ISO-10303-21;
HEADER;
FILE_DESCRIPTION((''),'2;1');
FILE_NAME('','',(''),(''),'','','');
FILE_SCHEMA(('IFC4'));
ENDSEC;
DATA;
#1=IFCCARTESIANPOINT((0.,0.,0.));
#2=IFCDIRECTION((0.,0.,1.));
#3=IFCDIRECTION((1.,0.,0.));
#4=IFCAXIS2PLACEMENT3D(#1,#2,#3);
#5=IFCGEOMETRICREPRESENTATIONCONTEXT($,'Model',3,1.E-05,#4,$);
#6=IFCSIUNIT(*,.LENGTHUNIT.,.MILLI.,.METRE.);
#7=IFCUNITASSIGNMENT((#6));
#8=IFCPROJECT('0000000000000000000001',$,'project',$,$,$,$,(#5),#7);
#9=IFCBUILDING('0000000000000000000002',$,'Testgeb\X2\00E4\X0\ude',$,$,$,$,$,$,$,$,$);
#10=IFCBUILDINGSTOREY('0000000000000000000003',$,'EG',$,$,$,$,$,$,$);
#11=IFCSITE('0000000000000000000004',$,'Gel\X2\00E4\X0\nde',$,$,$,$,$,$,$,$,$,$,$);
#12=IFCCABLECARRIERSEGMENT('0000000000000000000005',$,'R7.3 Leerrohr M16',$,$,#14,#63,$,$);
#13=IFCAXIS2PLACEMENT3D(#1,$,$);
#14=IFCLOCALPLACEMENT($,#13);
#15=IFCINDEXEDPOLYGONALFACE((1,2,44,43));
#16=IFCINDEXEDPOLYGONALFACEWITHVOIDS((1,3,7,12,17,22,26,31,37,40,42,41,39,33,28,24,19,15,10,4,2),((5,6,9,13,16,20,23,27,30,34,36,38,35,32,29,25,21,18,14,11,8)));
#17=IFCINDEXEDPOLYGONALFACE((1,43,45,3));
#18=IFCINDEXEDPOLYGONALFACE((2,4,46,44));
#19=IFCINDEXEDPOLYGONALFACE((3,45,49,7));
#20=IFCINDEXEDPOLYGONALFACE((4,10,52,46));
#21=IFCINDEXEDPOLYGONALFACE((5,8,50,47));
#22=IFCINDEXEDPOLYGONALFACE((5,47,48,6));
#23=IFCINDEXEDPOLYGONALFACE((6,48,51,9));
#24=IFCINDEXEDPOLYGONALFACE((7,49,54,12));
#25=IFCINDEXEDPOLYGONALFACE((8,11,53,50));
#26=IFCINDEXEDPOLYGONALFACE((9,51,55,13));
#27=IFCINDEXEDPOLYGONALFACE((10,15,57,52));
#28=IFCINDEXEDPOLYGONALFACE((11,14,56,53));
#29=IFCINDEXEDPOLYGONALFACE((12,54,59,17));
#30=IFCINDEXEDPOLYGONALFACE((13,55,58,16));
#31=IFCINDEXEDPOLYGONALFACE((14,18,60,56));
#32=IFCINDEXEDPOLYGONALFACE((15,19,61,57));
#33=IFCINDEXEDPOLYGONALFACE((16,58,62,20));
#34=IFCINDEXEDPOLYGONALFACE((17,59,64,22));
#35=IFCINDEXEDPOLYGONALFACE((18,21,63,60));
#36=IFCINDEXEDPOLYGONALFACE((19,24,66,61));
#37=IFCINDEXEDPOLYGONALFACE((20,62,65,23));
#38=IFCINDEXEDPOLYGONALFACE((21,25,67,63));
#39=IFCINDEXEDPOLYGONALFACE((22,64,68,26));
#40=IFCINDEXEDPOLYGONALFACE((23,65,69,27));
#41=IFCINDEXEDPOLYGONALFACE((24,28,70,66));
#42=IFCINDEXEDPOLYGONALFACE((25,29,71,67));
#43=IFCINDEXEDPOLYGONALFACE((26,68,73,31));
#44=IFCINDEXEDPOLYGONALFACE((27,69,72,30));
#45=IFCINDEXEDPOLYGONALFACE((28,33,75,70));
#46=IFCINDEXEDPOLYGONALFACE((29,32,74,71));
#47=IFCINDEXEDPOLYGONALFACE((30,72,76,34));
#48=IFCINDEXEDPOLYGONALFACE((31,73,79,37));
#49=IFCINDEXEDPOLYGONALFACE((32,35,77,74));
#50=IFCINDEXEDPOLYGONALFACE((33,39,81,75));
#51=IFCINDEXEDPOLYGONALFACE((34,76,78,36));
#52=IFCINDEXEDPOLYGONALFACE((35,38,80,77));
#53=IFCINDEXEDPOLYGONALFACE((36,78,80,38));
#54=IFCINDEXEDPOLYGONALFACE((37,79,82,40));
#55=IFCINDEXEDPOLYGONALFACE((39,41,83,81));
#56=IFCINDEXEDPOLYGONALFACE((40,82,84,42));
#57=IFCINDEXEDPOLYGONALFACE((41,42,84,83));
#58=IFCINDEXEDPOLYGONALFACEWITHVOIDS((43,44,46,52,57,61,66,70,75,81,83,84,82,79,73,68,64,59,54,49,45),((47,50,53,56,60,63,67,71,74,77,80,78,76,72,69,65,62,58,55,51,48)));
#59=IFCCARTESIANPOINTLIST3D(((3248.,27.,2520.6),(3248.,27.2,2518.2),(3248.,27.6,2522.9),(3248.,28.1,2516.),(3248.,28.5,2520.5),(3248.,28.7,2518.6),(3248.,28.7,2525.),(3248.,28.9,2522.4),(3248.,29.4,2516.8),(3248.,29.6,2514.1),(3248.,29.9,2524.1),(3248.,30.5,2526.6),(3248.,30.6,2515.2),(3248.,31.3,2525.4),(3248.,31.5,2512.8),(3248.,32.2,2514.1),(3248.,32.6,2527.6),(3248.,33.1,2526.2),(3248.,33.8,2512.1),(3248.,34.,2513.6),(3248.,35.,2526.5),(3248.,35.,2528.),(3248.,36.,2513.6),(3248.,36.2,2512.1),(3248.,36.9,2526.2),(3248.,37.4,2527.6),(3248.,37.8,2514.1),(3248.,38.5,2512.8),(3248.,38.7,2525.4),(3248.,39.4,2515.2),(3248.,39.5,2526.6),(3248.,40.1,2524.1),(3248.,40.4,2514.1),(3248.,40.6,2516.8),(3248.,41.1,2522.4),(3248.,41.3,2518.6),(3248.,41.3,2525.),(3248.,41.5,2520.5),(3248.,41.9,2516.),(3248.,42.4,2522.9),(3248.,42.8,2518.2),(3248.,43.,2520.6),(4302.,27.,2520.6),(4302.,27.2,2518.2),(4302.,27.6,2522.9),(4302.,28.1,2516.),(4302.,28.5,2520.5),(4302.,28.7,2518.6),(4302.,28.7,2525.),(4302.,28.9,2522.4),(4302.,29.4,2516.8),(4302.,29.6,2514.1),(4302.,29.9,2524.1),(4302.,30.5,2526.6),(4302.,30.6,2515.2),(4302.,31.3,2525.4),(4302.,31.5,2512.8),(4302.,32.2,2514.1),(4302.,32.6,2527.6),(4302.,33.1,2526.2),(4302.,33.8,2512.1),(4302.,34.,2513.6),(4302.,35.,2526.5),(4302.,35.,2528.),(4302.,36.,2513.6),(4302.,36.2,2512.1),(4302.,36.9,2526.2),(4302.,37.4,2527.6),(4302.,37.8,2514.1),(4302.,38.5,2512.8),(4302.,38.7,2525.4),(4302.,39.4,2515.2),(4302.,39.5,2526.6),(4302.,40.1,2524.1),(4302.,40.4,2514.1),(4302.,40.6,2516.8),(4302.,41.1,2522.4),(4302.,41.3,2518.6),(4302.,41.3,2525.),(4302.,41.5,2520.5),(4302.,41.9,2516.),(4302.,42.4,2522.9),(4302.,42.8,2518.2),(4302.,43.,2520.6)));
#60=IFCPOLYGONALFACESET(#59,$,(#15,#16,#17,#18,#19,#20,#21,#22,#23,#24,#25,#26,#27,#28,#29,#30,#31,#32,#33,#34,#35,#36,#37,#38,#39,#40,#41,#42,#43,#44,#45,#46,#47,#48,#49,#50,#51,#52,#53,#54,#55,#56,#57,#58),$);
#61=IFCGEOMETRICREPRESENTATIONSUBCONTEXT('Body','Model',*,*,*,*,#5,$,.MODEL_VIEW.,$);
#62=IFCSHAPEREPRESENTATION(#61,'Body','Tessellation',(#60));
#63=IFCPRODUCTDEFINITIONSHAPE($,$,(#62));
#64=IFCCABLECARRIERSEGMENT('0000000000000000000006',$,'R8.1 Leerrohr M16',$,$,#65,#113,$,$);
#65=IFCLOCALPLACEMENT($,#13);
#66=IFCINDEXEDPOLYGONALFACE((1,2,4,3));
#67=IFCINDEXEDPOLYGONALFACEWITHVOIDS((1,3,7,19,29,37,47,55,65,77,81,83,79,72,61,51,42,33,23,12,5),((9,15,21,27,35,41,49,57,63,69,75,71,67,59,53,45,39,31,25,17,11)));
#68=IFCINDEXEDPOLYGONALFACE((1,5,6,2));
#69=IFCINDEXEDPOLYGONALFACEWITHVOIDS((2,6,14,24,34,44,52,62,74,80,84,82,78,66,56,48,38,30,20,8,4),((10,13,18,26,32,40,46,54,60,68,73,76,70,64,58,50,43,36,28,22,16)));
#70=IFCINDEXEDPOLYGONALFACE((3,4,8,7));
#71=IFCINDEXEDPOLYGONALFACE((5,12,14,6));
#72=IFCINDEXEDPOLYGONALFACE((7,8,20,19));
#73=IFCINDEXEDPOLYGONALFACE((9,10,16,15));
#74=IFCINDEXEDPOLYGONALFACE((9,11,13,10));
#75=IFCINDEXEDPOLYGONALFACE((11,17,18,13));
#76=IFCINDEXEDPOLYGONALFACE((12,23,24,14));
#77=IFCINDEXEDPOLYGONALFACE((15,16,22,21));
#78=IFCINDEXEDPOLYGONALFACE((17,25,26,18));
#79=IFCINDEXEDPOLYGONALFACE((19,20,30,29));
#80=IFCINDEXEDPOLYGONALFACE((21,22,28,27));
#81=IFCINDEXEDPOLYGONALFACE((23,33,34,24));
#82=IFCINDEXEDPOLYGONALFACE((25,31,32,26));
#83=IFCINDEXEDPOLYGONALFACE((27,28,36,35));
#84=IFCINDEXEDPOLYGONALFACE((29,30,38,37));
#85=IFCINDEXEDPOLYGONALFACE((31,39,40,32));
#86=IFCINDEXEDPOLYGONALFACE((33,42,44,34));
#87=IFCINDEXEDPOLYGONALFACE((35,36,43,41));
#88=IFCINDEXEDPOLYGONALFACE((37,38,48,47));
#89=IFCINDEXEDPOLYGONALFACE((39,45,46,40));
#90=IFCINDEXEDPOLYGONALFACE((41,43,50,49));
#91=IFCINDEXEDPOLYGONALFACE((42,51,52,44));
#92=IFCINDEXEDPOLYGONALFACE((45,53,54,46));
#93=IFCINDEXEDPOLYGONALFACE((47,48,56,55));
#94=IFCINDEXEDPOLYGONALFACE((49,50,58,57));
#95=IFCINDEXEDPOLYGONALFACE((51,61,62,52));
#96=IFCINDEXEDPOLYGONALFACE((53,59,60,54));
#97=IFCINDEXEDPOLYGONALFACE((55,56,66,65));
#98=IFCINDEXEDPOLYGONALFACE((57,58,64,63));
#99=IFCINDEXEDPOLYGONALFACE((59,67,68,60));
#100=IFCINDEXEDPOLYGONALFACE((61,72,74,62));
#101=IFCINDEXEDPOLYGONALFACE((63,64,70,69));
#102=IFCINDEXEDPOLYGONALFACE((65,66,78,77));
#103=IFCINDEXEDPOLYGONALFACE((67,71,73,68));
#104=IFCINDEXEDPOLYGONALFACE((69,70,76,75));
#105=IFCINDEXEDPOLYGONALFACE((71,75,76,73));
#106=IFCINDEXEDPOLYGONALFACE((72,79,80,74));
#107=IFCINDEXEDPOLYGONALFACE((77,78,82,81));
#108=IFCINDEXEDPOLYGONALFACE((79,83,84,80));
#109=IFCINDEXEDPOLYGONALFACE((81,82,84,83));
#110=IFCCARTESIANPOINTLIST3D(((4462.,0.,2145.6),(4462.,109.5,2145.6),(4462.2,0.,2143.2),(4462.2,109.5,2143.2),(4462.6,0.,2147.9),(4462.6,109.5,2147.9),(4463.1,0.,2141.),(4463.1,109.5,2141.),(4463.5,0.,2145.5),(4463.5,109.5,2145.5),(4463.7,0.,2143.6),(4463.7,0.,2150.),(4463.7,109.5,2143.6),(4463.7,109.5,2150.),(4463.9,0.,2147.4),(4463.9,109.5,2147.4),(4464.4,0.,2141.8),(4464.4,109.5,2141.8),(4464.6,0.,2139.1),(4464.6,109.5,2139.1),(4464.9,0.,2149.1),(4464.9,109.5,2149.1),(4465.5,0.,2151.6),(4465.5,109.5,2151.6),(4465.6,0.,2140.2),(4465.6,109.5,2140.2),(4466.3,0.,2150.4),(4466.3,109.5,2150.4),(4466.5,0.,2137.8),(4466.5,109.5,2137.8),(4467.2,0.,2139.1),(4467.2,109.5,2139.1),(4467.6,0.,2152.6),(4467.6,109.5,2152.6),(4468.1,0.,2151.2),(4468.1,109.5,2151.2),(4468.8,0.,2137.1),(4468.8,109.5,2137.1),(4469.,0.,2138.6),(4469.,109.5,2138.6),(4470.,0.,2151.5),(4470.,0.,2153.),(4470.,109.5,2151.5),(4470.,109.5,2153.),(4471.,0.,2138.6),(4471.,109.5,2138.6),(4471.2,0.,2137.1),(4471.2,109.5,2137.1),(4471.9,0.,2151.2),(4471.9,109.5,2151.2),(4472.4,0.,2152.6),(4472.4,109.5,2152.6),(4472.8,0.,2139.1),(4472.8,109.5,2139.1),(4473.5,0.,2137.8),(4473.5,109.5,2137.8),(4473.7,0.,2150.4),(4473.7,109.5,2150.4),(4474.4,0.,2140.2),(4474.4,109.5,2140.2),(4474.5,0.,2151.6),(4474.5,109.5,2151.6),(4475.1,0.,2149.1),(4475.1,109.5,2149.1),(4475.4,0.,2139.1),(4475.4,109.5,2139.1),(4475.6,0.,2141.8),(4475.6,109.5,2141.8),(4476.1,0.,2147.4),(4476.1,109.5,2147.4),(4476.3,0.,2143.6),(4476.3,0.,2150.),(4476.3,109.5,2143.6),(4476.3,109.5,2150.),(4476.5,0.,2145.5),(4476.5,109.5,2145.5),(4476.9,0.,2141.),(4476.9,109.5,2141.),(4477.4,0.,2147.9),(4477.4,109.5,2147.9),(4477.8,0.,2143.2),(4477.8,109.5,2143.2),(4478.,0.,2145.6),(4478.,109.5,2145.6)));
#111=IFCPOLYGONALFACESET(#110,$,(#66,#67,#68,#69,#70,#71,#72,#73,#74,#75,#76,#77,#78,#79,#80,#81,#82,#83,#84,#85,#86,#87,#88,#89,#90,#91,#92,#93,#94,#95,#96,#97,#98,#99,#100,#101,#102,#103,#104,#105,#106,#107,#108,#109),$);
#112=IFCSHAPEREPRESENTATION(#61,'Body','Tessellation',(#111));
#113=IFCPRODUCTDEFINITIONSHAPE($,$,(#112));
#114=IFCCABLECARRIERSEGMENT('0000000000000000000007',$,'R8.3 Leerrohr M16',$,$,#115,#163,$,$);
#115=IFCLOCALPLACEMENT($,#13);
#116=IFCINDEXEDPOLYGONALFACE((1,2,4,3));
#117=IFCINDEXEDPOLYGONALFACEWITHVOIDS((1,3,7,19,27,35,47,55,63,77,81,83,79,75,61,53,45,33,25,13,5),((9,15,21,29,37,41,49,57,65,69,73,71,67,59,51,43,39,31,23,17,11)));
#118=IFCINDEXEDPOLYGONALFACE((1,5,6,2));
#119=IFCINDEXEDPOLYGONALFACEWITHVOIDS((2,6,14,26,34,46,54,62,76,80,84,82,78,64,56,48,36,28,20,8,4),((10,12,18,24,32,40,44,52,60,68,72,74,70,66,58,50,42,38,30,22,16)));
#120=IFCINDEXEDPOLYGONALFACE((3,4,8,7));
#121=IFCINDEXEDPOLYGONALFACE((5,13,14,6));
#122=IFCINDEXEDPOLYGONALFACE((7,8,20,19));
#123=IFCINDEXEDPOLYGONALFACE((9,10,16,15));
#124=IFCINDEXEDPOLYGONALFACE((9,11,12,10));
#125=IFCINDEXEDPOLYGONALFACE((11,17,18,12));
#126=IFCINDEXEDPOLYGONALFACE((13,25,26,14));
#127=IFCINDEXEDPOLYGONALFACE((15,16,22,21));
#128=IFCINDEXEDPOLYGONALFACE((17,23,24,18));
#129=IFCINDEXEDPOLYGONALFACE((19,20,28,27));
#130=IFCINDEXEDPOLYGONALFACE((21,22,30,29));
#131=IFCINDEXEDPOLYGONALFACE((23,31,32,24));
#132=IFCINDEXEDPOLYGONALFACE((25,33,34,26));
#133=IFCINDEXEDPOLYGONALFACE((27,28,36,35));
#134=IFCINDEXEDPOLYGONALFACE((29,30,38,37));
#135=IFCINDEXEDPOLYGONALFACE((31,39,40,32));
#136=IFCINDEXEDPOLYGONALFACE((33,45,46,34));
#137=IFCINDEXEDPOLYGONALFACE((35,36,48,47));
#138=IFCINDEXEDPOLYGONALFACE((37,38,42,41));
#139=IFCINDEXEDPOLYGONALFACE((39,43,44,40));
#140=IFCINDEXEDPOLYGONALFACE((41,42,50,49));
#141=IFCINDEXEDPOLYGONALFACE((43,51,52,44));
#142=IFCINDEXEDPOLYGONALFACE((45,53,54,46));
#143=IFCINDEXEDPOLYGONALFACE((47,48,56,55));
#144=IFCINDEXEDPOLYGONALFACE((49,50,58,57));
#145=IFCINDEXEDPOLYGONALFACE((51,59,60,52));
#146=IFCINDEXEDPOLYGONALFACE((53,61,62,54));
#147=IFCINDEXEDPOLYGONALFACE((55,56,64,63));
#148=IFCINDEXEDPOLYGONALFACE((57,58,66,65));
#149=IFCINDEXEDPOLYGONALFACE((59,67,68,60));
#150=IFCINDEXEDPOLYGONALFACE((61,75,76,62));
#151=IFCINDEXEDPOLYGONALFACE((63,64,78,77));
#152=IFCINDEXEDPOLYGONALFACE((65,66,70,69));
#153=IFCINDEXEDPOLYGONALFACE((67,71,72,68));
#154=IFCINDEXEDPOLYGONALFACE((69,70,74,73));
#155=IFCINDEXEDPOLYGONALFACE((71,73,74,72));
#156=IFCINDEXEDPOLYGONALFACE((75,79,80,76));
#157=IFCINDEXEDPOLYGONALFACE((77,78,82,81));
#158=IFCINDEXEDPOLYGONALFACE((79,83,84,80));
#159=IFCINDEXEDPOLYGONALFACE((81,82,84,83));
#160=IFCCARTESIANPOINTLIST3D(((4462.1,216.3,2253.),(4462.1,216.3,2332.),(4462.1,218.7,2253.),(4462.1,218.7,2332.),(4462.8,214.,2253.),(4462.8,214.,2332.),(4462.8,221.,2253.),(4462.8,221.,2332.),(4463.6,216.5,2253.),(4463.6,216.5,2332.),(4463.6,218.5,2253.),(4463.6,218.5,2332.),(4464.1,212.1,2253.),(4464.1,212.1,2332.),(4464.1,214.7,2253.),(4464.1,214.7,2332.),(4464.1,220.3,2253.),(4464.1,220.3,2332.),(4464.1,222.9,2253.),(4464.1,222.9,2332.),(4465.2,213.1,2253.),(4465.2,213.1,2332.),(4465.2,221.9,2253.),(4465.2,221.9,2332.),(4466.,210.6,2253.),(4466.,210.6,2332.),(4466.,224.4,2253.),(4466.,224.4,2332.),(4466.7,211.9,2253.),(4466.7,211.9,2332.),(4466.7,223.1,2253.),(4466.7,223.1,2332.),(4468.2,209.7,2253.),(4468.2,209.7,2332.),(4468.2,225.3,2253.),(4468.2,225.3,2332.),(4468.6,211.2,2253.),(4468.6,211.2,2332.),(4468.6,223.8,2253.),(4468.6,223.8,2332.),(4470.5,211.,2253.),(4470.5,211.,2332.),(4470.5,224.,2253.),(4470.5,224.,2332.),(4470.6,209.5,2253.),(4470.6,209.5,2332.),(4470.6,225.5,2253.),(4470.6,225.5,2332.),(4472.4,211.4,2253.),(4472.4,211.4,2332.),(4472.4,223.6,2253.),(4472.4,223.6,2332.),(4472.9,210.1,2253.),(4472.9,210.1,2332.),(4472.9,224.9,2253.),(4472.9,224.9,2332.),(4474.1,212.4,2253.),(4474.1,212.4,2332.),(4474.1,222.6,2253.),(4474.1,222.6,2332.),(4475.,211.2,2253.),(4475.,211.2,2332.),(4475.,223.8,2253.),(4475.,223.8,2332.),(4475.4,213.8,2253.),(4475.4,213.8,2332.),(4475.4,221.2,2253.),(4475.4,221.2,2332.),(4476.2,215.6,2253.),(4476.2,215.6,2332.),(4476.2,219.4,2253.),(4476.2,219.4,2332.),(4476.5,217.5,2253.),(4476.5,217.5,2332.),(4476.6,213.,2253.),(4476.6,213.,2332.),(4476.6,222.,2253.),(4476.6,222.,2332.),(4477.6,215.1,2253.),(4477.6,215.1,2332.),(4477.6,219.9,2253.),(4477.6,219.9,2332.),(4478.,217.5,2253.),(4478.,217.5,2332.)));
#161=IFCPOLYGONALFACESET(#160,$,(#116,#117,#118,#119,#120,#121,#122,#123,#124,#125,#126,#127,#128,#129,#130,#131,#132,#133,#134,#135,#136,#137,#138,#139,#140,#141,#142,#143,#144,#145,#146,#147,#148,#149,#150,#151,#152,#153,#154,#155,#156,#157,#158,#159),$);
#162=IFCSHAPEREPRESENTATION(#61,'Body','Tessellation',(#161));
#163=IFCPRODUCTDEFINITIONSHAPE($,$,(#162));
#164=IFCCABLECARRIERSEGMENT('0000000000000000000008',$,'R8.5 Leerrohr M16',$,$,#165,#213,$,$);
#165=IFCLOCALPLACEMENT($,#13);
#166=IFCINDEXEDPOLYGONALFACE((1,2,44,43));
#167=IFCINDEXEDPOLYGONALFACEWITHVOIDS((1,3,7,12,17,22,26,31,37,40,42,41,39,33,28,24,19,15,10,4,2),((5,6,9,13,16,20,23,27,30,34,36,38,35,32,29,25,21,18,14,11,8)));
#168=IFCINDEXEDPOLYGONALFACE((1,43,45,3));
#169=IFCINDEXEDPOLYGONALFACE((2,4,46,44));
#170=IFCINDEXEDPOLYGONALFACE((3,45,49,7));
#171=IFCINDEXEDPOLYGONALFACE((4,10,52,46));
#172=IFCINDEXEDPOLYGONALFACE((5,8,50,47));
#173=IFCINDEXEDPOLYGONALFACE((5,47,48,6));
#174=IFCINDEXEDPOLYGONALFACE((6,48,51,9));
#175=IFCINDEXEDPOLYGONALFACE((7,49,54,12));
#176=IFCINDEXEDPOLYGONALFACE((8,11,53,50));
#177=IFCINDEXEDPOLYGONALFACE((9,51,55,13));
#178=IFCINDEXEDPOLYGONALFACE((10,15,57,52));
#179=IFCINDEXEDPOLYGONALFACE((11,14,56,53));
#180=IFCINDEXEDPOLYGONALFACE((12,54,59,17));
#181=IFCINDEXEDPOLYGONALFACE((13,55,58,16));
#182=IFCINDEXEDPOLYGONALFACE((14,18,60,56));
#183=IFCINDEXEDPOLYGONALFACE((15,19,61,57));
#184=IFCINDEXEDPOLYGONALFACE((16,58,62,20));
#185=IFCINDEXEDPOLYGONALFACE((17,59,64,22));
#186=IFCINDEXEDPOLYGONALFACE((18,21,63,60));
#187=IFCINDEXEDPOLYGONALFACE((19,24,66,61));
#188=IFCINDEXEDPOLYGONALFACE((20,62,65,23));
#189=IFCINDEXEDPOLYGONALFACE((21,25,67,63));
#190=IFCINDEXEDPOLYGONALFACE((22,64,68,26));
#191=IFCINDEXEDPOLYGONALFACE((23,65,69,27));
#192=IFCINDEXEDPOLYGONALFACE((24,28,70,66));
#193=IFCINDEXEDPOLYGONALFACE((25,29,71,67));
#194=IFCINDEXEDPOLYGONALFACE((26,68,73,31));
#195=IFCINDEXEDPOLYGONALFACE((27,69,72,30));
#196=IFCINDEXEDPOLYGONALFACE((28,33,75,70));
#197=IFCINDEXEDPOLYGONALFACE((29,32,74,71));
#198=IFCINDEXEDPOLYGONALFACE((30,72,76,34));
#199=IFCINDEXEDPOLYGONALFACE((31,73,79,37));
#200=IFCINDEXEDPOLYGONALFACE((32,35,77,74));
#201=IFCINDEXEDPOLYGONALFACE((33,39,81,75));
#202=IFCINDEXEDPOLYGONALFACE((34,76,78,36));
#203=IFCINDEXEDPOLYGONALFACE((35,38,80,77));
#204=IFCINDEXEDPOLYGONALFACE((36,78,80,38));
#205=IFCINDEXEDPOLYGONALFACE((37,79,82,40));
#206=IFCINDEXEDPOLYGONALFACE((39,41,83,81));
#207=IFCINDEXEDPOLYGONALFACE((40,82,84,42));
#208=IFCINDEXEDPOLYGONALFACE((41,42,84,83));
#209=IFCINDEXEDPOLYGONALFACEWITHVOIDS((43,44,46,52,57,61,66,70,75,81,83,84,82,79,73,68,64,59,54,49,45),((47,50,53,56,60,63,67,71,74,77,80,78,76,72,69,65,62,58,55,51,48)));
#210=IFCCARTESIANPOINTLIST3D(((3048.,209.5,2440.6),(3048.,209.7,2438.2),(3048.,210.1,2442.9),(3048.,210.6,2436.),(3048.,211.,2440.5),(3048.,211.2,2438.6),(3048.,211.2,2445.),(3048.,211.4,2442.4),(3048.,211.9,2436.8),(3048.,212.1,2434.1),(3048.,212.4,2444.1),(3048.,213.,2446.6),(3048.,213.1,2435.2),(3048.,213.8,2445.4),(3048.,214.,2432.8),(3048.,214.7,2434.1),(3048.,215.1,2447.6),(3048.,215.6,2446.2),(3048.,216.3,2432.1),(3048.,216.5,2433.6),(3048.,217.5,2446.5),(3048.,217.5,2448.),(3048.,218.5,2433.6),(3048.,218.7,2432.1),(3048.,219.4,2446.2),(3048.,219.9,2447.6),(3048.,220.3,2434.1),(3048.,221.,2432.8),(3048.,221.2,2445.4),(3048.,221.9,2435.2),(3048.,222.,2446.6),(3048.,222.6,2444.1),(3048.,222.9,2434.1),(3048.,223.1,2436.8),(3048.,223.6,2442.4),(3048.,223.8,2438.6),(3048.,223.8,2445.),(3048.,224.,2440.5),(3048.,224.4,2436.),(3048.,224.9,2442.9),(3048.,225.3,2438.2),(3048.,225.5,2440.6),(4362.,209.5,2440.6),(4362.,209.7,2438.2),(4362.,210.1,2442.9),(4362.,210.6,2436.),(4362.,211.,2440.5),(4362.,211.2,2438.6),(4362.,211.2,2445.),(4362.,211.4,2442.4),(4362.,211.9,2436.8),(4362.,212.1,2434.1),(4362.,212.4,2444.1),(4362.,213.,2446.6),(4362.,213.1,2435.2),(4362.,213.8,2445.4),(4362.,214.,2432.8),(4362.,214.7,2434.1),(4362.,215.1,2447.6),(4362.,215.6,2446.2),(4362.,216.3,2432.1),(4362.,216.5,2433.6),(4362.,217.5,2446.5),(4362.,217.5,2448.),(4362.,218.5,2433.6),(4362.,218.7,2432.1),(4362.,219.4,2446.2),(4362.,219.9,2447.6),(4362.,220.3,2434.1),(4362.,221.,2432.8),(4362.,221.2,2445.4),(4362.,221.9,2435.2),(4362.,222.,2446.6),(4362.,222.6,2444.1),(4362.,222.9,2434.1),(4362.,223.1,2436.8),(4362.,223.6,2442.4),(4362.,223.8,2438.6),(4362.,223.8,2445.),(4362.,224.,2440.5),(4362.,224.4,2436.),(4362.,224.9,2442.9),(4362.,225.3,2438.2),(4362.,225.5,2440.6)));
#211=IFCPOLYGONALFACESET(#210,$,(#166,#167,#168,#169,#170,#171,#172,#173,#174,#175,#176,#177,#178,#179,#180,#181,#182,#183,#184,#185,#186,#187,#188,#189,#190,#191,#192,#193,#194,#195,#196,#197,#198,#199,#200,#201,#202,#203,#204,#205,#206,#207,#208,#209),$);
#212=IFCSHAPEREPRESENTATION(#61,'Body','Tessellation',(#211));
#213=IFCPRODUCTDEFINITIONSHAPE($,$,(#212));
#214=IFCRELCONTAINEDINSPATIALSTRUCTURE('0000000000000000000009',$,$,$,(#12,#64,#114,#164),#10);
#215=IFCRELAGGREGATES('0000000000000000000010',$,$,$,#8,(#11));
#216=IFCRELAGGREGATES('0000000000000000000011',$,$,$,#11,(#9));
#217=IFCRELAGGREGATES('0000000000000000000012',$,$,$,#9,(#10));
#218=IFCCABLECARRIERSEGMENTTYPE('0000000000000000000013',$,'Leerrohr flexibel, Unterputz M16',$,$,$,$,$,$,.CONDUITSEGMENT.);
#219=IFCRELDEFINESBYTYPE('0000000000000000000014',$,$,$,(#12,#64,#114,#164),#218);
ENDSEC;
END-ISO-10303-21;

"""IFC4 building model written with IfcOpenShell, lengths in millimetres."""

from ifc_helpers import new_model, si_unit, frame, origin_with_axes, place, context, subcontext, project, spatial, hollow_circle, extrude, type_object, element, save


model = new_model("IFC4")

# Units and contexts
model_context = context("Model", 3, precision=1e-05, world=origin_with_axes())
body_context = subcontext(model_context, "Body", "Model", "MODEL_VIEW")
ifc_project = project(units=[si_unit("LENGTHUNIT", "METRE", prefix="MILLI")], contexts=[model_context])

# Site, building, storey
site = spatial("IfcSite", under=ifc_project, Name="Gelände")
building = spatial("IfcBuilding", under=site, Name="Testgebäude")
storey = spatial("IfcBuildingStorey", under=building, Name="EG")

# Cable carrier segments
cable_carrier_segment_type_1 = type_object("IfcCableCarrierSegmentType", Name="Leerrohr flexibel, Unterputz M16", PredefinedType="CONDUITSEGMENT")
cable_carrier_segment_1_placement = place(None, frame((4302.0, 35.0, 2520.0), z_axis=(-1.0, 0.0, 0.0), x_axis=(0.0, 0.0, 1.0)))
element("IfcCableCarrierSegment", 1, at=cable_carrier_segment_1_placement, inside=storey, type_object=cable_carrier_segment_type_1, Name="R7.3 Leerrohr M16", context=body_context, shape_type="SweptSolid", body=[
    extrude(hollow_circle(Radius=8.0, WallThickness=1.5), None, (0.0, 0.0, 1.0), 1054.0),
])
cable_carrier_segment_2_placement = place(None, frame((4470.0, 0.0, 2145.0), z_axis=(0.0, 1.0, 0.0), x_axis=(0.0, 0.0, 1.0)))
element("IfcCableCarrierSegment", 2, at=cable_carrier_segment_2_placement, inside=storey, type_object=cable_carrier_segment_type_1, Name="R8.1 Leerrohr M16", context=body_context, shape_type="SweptSolid", body=[
    extrude(hollow_circle(Radius=8.0, WallThickness=1.5), None, (0.0, 0.0, 1.0), 109.5),
])
cable_carrier_segment_3_placement = place(None, frame((4470.0, 217.5, 2253.0), z_axis=(0.0, 0.0, 1.0), x_axis=(1.0, 0.0, 0.0)))
element("IfcCableCarrierSegment", 3, at=cable_carrier_segment_3_placement, inside=storey, type_object=cable_carrier_segment_type_1, Name="R8.3 Leerrohr M16", context=body_context, shape_type="SweptSolid", body=[
    extrude(hollow_circle(Radius=8.0, WallThickness=1.5), None, (0.0, 0.0, 1.0), 79.0),
])
cable_carrier_segment_4_placement = place(None, frame((4362.0, 217.5, 2440.0), z_axis=(-1.0, 0.0, 0.0), x_axis=(0.0, 0.0, 1.0)))
element("IfcCableCarrierSegment", 4, at=cable_carrier_segment_4_placement, inside=storey, type_object=cable_carrier_segment_type_1, Name="R8.5 Leerrohr M16", context=body_context, shape_type="SweptSolid", body=[
    extrude(hollow_circle(Radius=8.0, WallThickness=1.5), None, (0.0, 0.0, 1.0), 1314.0),
])

save(model, "model.ifc")
